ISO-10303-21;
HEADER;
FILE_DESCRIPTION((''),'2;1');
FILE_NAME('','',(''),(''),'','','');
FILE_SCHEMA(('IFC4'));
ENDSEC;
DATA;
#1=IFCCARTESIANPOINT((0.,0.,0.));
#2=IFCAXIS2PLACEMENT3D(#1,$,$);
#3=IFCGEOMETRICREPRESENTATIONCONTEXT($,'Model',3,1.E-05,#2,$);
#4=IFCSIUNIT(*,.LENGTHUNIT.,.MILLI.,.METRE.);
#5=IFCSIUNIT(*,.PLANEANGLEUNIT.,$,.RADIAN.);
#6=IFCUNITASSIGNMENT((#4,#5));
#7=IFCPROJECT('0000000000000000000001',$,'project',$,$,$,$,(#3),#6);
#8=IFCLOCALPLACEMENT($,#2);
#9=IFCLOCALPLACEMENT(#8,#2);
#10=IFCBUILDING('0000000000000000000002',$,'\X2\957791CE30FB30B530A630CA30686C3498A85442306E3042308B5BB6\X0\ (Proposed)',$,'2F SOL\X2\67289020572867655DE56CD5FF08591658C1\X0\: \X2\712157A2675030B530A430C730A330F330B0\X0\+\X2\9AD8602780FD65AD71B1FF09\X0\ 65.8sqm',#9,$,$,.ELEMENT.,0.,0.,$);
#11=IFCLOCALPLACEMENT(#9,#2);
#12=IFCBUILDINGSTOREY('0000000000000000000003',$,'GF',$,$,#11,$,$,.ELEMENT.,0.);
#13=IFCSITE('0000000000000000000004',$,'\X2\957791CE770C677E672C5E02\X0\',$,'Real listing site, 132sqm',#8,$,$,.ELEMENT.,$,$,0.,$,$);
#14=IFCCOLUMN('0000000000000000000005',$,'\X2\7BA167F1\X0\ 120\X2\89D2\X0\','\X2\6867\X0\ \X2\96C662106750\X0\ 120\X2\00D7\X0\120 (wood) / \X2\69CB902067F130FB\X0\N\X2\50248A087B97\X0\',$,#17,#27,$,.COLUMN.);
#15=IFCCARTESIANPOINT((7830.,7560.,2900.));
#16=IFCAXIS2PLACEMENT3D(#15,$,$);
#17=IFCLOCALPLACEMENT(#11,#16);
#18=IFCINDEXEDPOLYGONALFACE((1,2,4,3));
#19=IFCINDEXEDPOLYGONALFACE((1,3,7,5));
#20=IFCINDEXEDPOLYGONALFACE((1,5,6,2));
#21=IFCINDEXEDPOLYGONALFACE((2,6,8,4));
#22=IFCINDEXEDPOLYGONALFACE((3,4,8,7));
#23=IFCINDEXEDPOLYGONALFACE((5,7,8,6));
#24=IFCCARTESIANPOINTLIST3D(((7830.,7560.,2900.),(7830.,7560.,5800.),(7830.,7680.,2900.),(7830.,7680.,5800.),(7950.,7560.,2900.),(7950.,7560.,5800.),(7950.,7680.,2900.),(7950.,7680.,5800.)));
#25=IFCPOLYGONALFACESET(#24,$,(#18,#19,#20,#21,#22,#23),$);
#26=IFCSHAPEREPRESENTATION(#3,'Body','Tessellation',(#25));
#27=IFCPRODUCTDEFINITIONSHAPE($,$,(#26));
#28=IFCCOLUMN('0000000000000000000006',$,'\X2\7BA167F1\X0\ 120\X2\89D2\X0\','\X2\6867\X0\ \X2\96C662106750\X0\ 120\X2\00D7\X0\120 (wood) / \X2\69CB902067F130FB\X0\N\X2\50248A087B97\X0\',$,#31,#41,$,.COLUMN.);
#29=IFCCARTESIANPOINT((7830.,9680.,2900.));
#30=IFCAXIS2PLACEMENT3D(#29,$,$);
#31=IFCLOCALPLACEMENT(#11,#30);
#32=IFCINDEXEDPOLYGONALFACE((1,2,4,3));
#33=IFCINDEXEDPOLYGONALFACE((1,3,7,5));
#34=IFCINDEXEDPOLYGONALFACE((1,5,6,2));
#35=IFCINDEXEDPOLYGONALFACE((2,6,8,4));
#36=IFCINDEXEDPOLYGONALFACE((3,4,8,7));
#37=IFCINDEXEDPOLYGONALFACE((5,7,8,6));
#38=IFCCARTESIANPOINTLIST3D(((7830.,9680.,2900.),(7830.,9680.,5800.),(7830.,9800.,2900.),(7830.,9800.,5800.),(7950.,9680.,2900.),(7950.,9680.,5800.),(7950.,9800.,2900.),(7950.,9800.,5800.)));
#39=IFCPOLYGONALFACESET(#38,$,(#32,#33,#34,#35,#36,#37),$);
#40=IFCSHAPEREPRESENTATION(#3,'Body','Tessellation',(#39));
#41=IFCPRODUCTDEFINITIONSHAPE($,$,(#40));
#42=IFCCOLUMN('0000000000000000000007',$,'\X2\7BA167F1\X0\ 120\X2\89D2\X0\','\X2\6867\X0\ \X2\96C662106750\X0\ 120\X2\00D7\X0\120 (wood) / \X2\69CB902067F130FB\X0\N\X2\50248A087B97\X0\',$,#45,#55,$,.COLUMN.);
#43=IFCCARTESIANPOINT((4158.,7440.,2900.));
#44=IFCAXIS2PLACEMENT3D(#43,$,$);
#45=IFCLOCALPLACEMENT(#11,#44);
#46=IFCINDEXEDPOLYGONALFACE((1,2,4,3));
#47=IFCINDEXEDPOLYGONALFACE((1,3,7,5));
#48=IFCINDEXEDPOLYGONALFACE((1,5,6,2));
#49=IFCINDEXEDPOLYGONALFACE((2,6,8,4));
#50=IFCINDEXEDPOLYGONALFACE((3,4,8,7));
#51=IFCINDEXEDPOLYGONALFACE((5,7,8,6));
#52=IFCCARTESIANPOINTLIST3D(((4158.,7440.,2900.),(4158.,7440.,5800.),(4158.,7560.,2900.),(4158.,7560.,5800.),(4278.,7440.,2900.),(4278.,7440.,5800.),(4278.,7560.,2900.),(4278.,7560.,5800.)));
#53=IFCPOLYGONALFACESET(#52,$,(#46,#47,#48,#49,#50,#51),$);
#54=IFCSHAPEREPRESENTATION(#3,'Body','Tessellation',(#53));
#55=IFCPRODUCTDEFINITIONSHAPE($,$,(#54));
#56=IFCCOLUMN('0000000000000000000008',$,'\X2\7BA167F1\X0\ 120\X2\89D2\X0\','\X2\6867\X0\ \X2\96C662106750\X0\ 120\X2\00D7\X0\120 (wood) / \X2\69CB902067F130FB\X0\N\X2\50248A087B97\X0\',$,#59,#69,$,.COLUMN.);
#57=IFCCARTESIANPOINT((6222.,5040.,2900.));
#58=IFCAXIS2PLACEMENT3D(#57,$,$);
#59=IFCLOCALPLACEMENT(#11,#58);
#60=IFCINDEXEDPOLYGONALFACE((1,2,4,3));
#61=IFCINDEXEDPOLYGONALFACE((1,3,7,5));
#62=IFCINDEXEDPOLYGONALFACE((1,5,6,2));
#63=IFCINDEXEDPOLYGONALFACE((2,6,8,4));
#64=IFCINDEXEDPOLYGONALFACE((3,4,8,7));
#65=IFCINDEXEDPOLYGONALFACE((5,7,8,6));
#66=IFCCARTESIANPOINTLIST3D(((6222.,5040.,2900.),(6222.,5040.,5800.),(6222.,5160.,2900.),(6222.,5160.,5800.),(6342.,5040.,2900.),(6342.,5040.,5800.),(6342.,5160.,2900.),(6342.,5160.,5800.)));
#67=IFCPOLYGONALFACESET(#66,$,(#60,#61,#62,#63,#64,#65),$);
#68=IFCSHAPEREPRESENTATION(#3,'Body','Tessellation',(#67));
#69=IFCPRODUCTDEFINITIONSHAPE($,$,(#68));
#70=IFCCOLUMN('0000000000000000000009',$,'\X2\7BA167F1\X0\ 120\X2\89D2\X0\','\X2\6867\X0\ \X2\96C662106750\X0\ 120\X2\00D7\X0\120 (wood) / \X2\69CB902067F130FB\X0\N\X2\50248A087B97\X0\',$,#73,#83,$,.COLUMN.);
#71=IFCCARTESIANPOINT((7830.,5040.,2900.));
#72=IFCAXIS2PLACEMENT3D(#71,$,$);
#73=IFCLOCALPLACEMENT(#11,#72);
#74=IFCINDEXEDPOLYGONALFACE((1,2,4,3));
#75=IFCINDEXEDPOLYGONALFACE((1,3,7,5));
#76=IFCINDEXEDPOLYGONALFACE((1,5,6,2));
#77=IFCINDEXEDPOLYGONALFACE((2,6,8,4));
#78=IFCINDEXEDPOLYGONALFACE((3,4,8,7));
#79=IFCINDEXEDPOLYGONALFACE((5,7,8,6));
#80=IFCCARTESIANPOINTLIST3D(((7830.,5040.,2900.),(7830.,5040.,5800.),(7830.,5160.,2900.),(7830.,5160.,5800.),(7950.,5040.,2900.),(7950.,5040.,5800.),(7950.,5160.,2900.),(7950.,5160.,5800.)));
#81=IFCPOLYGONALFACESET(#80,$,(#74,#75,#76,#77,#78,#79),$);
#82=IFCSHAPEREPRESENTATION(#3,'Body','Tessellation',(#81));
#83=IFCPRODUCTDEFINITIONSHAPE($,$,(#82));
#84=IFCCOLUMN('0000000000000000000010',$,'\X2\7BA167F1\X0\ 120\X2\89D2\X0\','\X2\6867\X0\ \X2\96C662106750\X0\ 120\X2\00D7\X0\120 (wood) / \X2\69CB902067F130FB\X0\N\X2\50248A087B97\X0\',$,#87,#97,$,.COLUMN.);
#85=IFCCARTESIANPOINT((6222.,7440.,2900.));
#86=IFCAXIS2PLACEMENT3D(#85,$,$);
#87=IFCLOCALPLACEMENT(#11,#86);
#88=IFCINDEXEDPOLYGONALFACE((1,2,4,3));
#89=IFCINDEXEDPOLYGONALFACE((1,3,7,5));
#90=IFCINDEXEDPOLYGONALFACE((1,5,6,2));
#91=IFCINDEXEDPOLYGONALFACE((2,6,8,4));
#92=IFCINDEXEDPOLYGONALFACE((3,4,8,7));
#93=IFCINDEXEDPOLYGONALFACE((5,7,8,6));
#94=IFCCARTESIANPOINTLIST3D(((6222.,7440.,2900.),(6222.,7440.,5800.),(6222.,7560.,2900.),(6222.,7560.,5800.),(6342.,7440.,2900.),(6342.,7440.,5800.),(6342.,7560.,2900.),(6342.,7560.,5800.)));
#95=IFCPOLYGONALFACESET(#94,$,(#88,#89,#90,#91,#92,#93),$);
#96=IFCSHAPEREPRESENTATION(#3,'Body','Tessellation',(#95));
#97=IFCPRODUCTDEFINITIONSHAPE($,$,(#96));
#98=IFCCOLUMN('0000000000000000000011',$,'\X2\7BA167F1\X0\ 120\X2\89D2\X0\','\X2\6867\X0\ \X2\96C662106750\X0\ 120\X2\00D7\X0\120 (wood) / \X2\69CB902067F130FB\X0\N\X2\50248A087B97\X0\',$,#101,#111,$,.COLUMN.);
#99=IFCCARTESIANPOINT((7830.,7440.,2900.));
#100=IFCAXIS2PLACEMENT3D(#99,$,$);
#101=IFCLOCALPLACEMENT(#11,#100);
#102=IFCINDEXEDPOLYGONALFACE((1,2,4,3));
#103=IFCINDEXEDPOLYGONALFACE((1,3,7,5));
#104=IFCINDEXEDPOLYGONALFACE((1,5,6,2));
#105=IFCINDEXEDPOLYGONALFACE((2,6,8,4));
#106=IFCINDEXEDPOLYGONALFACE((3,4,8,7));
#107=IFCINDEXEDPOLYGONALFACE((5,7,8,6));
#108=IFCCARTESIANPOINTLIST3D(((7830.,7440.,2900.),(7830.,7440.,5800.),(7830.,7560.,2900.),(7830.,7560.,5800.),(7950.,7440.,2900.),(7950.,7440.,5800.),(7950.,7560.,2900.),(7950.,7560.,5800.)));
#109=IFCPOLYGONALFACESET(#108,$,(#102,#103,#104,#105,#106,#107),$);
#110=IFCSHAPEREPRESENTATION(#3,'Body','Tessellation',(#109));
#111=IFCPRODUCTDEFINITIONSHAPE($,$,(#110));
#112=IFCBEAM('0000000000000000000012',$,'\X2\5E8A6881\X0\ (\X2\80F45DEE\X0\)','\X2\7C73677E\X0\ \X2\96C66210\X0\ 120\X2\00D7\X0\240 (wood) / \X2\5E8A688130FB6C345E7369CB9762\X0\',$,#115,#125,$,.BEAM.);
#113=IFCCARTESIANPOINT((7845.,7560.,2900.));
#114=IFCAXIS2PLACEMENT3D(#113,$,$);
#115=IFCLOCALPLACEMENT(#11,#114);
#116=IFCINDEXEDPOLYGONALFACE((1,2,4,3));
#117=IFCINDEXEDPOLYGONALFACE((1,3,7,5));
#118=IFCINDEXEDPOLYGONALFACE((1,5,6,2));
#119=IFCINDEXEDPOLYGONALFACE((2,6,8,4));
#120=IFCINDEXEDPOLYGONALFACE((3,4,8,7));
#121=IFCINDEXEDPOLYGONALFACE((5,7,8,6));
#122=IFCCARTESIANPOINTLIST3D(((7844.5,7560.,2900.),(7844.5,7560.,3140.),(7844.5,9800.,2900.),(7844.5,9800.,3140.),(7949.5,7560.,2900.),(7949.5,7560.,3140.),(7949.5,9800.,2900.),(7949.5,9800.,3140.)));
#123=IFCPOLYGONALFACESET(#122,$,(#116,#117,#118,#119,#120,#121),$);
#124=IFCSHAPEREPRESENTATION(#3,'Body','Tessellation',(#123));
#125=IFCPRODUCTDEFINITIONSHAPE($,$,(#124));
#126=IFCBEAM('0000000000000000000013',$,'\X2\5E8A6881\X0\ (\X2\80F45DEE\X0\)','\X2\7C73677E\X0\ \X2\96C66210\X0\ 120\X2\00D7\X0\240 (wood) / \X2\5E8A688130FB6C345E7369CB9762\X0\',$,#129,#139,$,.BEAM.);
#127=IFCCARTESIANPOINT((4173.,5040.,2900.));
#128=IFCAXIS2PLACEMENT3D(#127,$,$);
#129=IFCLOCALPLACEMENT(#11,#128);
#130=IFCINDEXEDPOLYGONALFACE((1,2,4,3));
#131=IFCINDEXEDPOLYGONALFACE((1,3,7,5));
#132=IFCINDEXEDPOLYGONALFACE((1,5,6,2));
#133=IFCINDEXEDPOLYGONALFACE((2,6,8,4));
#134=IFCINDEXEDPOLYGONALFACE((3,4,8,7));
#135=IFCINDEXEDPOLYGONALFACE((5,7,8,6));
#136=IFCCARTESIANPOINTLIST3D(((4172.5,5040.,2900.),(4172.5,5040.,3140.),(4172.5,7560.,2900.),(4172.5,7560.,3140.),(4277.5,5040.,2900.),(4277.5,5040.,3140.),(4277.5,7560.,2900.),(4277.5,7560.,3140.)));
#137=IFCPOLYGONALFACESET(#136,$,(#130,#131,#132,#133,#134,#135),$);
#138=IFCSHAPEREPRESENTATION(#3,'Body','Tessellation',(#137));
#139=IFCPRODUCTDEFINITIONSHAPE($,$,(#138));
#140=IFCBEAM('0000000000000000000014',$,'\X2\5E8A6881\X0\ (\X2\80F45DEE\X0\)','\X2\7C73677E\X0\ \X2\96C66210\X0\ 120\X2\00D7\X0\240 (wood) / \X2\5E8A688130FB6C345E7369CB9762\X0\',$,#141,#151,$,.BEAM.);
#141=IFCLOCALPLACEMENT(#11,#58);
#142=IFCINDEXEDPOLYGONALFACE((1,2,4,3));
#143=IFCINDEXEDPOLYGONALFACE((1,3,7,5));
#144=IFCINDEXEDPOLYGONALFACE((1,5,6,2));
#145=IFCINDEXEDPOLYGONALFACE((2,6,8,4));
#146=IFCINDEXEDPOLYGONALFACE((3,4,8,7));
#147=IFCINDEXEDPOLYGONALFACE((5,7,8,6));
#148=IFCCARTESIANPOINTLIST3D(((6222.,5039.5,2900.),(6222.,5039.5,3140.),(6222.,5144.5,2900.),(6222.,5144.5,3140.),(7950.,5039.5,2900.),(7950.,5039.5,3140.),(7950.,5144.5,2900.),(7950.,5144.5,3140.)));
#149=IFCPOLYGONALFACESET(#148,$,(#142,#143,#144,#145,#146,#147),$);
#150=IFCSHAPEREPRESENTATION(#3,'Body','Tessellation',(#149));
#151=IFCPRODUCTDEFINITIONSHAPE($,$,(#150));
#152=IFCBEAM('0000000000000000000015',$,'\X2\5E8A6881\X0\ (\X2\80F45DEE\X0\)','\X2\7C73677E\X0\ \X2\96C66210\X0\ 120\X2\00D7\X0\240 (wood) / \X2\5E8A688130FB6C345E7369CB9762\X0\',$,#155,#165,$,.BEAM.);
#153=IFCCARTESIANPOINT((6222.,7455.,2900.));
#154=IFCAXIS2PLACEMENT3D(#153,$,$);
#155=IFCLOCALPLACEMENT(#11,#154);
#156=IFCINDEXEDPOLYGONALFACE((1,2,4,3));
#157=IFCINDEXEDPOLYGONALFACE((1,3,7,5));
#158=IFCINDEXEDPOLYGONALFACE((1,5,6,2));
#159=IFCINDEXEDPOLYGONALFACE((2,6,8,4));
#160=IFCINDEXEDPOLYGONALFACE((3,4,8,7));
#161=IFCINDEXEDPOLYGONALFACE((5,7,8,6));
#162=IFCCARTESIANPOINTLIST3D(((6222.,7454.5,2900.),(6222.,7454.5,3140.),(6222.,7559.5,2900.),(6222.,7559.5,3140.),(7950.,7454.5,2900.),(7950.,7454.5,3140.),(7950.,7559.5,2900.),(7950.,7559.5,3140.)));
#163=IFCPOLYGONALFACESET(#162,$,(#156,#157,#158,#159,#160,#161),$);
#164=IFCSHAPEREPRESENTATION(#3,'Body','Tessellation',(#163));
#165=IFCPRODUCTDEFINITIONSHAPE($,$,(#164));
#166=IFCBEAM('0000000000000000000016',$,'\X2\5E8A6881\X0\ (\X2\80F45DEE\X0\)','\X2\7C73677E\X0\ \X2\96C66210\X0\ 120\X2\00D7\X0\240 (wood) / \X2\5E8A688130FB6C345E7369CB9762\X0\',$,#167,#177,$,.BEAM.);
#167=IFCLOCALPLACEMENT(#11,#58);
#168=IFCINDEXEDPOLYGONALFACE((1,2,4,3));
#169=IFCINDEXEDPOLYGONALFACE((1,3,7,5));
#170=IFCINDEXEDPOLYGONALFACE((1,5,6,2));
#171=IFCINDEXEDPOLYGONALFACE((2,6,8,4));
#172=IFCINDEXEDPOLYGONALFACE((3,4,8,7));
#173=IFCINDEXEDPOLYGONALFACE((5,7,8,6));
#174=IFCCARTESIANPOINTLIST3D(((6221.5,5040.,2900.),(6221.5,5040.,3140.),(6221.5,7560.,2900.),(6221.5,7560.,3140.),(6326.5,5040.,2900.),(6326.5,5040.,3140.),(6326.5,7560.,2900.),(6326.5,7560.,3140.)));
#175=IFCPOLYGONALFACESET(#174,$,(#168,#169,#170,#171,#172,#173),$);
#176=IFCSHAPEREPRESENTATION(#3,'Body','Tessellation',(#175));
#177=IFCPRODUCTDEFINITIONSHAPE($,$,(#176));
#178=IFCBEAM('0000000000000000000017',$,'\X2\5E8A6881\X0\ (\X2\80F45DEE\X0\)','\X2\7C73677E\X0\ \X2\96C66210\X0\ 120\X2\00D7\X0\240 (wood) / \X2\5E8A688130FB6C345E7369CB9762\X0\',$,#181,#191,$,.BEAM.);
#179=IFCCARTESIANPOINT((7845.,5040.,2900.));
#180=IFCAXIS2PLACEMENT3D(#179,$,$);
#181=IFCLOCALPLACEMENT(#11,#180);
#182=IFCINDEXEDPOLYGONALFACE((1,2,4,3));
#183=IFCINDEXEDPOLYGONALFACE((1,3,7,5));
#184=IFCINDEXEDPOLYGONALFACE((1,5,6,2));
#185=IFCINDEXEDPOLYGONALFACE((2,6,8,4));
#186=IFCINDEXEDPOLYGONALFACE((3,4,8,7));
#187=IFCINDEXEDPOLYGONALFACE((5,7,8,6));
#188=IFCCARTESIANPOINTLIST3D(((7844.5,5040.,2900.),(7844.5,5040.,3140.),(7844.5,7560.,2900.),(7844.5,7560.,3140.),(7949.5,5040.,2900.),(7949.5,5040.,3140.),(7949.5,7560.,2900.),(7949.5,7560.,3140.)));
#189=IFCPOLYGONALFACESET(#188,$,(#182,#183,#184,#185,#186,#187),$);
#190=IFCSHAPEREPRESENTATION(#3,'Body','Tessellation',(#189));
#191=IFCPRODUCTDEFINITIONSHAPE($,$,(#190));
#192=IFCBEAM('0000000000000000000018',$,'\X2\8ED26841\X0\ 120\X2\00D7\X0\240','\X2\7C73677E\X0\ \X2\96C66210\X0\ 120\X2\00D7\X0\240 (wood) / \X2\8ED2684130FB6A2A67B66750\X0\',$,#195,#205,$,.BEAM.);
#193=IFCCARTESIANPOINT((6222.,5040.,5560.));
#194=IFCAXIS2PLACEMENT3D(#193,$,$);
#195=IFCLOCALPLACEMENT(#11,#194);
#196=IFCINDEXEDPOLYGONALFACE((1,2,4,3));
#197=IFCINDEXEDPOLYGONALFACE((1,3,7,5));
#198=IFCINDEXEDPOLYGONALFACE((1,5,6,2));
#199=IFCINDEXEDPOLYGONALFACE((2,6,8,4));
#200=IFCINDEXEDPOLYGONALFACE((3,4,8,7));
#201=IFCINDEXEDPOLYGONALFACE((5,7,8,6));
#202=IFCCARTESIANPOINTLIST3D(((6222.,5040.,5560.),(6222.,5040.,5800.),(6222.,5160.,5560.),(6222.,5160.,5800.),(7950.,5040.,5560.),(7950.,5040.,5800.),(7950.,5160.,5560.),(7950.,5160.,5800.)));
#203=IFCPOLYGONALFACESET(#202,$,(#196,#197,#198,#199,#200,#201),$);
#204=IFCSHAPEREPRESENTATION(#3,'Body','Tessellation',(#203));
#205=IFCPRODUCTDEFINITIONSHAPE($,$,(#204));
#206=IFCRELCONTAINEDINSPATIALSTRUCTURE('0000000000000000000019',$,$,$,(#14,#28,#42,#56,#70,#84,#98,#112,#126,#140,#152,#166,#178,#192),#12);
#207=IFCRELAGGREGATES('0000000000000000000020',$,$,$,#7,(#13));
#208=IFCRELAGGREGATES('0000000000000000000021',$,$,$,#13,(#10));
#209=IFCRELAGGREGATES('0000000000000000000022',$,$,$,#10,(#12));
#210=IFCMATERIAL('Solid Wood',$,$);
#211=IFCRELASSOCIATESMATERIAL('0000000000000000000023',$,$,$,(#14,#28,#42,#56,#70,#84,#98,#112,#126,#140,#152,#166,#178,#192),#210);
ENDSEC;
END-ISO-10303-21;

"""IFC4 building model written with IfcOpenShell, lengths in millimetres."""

from ifc_helpers import new_model, si_unit, frame, frame_2d, origin, place, context, project, spatial, rectangle, extrude, material, element, save


model = new_model("IFC4")

# Units and contexts
model_context = context("Model", 3, precision=1e-05, world=origin())
ifc_project = project(units=[si_unit("LENGTHUNIT", "METRE", prefix="MILLI"), si_unit("PLANEANGLEUNIT", "RADIAN")], contexts=[model_context])

# Site, building, storey
site_placement = place(None, origin())
site = spatial("IfcSite", under=ifc_project, at=site_placement, Name="長野県松本市", ObjectType="Real listing site, 132sqm", CompositionType="ELEMENT", RefElevation=0.0)
building_placement = place(site_placement, origin())
building = spatial("IfcBuilding", under=site, at=building_placement, Name="長野・サウナと水風呂のある家 (Proposed)", ObjectType="2F SOL木造在来工法（外壁: 無垢材サイディング+高性能断熱） 65.8sqm", CompositionType="ELEMENT", ElevationOfRefHeight=0.0, ElevationOfTerrain=0.0)
storey_placement = place(building_placement, origin())
storey = spatial("IfcBuildingStorey", under=building, at=storey_placement, Name="GF", CompositionType="ELEMENT", Elevation=0.0)

# Columns
ifc_material_1 = material(Name="Solid Wood")
column_1_placement = place(storey_placement, frame((7830.0, 7560.0, 2900.0)))
element("IfcColumn", 1, at=column_1_placement, inside=storey, material=ifc_material_1, Name="管柱 120角", Description="桧 集成材 120×120 (wood) / 構造柱・N値計算", PredefinedType="COLUMN", context=model_context, shape_type="SweptSolid", body=[
    extrude(rectangle(XDim=120.0, YDim=120.0, at=frame_2d((60.0, 60.0))), frame((7830.0, 7560.0, 2900.0)), (0.0, 0.0, 1.0), 2900.0),
])
column_2_placement = place(storey_placement, frame((7830.0, 9680.0, 2900.0)))
element("IfcColumn", 2, at=column_2_placement, inside=storey, material=ifc_material_1, Name="管柱 120角", Description="桧 集成材 120×120 (wood) / 構造柱・N値計算", PredefinedType="COLUMN", context=model_context, shape_type="SweptSolid", body=[
    extrude(rectangle(XDim=120.0, YDim=120.0, at=frame_2d((60.0, 60.0))), frame((7830.0, 9680.0, 2900.0)), (0.0, 0.0, 1.0), 2900.0),
])
column_3_placement = place(storey_placement, frame((4158.0, 7440.0, 2900.0)))
element("IfcColumn", 3, at=column_3_placement, inside=storey, material=ifc_material_1, Name="管柱 120角", Description="桧 集成材 120×120 (wood) / 構造柱・N値計算", PredefinedType="COLUMN", context=model_context, shape_type="SweptSolid", body=[
    extrude(rectangle(XDim=120.0, YDim=120.0, at=frame_2d((60.0, 60.0))), frame((4158.0, 7440.0, 2900.0)), (0.0, 0.0, 1.0), 2900.0),
])
column_4_placement = place(storey_placement, frame((6222.0, 5040.0, 2900.0)))
element("IfcColumn", 4, at=column_4_placement, inside=storey, material=ifc_material_1, Name="管柱 120角", Description="桧 集成材 120×120 (wood) / 構造柱・N値計算", PredefinedType="COLUMN", context=model_context, shape_type="SweptSolid", body=[
    extrude(rectangle(XDim=120.0, YDim=120.0, at=frame_2d((60.0, 60.0))), frame((6222.0, 5040.0, 2900.0)), (0.0, 0.0, 1.0), 2900.0),
])
column_5_placement = place(storey_placement, frame((7830.0, 5040.0, 2900.0)))
element("IfcColumn", 5, at=column_5_placement, inside=storey, material=ifc_material_1, Name="管柱 120角", Description="桧 集成材 120×120 (wood) / 構造柱・N値計算", PredefinedType="COLUMN", context=model_context, shape_type="SweptSolid", body=[
    extrude(rectangle(XDim=120.0, YDim=120.0, at=frame_2d((60.0, 60.0))), frame((7830.0, 5040.0, 2900.0)), (0.0, 0.0, 1.0), 2900.0),
])
column_6_placement = place(storey_placement, frame((6222.0, 7440.0, 2900.0)))
element("IfcColumn", 6, at=column_6_placement, inside=storey, material=ifc_material_1, Name="管柱 120角", Description="桧 集成材 120×120 (wood) / 構造柱・N値計算", PredefinedType="COLUMN", context=model_context, shape_type="SweptSolid", body=[
    extrude(rectangle(XDim=120.0, YDim=120.0, at=frame_2d((60.0, 60.0))), frame((6222.0, 7440.0, 2900.0)), (0.0, 0.0, 1.0), 2900.0),
])
column_7_placement = place(storey_placement, frame((7830.0, 7440.0, 2900.0)))
element("IfcColumn", 7, at=column_7_placement, inside=storey, material=ifc_material_1, Name="管柱 120角", Description="桧 集成材 120×120 (wood) / 構造柱・N値計算", PredefinedType="COLUMN", context=model_context, shape_type="SweptSolid", body=[
    extrude(rectangle(XDim=120.0, YDim=120.0, at=frame_2d((60.0, 60.0))), frame((7830.0, 7440.0, 2900.0)), (0.0, 0.0, 1.0), 2900.0),
])

# Beams
beam_1_placement = place(storey_placement, frame((7845.0, 7560.0, 2900.0)))
element("IfcBeam", 8, at=beam_1_placement, inside=storey, material=ifc_material_1, Name="床梁 (胴差)", Description="米松 集成 120×240 (wood) / 床梁・水平構面", PredefinedType="BEAM", context=model_context, shape_type="SweptSolid", body=[
    extrude(rectangle(XDim=105.0, YDim=2240.0, at=frame_2d((52.0, 1120.0))), frame((7845.0, 7560.0, 2900.0)), (0.0, 0.0, 1.0), 240.0),
])
beam_2_placement = place(storey_placement, frame((4173.0, 5040.0, 2900.0)))
element("IfcBeam", 9, at=beam_2_placement, inside=storey, material=ifc_material_1, Name="床梁 (胴差)", Description="米松 集成 120×240 (wood) / 床梁・水平構面", PredefinedType="BEAM", context=model_context, shape_type="SweptSolid", body=[
    extrude(rectangle(XDim=105.0, YDim=2520.0, at=frame_2d((52.0, 1260.0))), frame((4173.0, 5040.0, 2900.0)), (0.0, 0.0, 1.0), 240.0),
])
beam_3_placement = place(storey_placement, frame((6222.0, 5040.0, 2900.0)))
element("IfcBeam", 10, at=beam_3_placement, inside=storey, material=ifc_material_1, Name="床梁 (胴差)", Description="米松 集成 120×240 (wood) / 床梁・水平構面", PredefinedType="BEAM", context=model_context, shape_type="SweptSolid", body=[
    extrude(rectangle(XDim=1728.0, YDim=105.0, at=frame_2d((864.0, 52.0))), frame((6222.0, 5040.0, 2900.0)), (0.0, 0.0, 1.0), 240.0),
])
beam_4_placement = place(storey_placement, frame((6222.0, 7455.0, 2900.0)))
element("IfcBeam", 11, at=beam_4_placement, inside=storey, material=ifc_material_1, Name="床梁 (胴差)", Description="米松 集成 120×240 (wood) / 床梁・水平構面", PredefinedType="BEAM", context=model_context, shape_type="SweptSolid", body=[
    extrude(rectangle(XDim=1728.0, YDim=105.0, at=frame_2d((864.0, 52.0))), frame((6222.0, 7455.0, 2900.0)), (0.0, 0.0, 1.0), 240.0),
])
beam_5_placement = place(storey_placement, frame((6222.0, 5040.0, 2900.0)))
element("IfcBeam", 12, at=beam_5_placement, inside=storey, material=ifc_material_1, Name="床梁 (胴差)", Description="米松 集成 120×240 (wood) / 床梁・水平構面", PredefinedType="BEAM", context=model_context, shape_type="SweptSolid", body=[
    extrude(rectangle(XDim=105.0, YDim=2520.0, at=frame_2d((52.0, 1260.0))), frame((6222.0, 5040.0, 2900.0)), (0.0, 0.0, 1.0), 240.0),
])
beam_6_placement = place(storey_placement, frame((7845.0, 5040.0, 2900.0)))
element("IfcBeam", 13, at=beam_6_placement, inside=storey, material=ifc_material_1, Name="床梁 (胴差)", Description="米松 集成 120×240 (wood) / 床梁・水平構面", PredefinedType="BEAM", context=model_context, shape_type="SweptSolid", body=[
    extrude(rectangle(XDim=105.0, YDim=2520.0, at=frame_2d((52.0, 1260.0))), frame((7845.0, 5040.0, 2900.0)), (0.0, 0.0, 1.0), 240.0),
])
beam_7_placement = place(storey_placement, frame((6222.0, 5040.0, 5560.0)))
element("IfcBeam", 14, at=beam_7_placement, inside=storey, material=ifc_material_1, Name="軒桁 120×240", Description="米松 集成 120×240 (wood) / 軒桁・横架材", PredefinedType="BEAM", context=model_context, shape_type="SweptSolid", body=[
    extrude(rectangle(XDim=1728.0, YDim=120.0, at=frame_2d((864.0, 60.0))), frame((6222.0, 5040.0, 5560.0)), (0.0, 0.0, 1.0), 240.0),
])

save(model, "model.ifc")
